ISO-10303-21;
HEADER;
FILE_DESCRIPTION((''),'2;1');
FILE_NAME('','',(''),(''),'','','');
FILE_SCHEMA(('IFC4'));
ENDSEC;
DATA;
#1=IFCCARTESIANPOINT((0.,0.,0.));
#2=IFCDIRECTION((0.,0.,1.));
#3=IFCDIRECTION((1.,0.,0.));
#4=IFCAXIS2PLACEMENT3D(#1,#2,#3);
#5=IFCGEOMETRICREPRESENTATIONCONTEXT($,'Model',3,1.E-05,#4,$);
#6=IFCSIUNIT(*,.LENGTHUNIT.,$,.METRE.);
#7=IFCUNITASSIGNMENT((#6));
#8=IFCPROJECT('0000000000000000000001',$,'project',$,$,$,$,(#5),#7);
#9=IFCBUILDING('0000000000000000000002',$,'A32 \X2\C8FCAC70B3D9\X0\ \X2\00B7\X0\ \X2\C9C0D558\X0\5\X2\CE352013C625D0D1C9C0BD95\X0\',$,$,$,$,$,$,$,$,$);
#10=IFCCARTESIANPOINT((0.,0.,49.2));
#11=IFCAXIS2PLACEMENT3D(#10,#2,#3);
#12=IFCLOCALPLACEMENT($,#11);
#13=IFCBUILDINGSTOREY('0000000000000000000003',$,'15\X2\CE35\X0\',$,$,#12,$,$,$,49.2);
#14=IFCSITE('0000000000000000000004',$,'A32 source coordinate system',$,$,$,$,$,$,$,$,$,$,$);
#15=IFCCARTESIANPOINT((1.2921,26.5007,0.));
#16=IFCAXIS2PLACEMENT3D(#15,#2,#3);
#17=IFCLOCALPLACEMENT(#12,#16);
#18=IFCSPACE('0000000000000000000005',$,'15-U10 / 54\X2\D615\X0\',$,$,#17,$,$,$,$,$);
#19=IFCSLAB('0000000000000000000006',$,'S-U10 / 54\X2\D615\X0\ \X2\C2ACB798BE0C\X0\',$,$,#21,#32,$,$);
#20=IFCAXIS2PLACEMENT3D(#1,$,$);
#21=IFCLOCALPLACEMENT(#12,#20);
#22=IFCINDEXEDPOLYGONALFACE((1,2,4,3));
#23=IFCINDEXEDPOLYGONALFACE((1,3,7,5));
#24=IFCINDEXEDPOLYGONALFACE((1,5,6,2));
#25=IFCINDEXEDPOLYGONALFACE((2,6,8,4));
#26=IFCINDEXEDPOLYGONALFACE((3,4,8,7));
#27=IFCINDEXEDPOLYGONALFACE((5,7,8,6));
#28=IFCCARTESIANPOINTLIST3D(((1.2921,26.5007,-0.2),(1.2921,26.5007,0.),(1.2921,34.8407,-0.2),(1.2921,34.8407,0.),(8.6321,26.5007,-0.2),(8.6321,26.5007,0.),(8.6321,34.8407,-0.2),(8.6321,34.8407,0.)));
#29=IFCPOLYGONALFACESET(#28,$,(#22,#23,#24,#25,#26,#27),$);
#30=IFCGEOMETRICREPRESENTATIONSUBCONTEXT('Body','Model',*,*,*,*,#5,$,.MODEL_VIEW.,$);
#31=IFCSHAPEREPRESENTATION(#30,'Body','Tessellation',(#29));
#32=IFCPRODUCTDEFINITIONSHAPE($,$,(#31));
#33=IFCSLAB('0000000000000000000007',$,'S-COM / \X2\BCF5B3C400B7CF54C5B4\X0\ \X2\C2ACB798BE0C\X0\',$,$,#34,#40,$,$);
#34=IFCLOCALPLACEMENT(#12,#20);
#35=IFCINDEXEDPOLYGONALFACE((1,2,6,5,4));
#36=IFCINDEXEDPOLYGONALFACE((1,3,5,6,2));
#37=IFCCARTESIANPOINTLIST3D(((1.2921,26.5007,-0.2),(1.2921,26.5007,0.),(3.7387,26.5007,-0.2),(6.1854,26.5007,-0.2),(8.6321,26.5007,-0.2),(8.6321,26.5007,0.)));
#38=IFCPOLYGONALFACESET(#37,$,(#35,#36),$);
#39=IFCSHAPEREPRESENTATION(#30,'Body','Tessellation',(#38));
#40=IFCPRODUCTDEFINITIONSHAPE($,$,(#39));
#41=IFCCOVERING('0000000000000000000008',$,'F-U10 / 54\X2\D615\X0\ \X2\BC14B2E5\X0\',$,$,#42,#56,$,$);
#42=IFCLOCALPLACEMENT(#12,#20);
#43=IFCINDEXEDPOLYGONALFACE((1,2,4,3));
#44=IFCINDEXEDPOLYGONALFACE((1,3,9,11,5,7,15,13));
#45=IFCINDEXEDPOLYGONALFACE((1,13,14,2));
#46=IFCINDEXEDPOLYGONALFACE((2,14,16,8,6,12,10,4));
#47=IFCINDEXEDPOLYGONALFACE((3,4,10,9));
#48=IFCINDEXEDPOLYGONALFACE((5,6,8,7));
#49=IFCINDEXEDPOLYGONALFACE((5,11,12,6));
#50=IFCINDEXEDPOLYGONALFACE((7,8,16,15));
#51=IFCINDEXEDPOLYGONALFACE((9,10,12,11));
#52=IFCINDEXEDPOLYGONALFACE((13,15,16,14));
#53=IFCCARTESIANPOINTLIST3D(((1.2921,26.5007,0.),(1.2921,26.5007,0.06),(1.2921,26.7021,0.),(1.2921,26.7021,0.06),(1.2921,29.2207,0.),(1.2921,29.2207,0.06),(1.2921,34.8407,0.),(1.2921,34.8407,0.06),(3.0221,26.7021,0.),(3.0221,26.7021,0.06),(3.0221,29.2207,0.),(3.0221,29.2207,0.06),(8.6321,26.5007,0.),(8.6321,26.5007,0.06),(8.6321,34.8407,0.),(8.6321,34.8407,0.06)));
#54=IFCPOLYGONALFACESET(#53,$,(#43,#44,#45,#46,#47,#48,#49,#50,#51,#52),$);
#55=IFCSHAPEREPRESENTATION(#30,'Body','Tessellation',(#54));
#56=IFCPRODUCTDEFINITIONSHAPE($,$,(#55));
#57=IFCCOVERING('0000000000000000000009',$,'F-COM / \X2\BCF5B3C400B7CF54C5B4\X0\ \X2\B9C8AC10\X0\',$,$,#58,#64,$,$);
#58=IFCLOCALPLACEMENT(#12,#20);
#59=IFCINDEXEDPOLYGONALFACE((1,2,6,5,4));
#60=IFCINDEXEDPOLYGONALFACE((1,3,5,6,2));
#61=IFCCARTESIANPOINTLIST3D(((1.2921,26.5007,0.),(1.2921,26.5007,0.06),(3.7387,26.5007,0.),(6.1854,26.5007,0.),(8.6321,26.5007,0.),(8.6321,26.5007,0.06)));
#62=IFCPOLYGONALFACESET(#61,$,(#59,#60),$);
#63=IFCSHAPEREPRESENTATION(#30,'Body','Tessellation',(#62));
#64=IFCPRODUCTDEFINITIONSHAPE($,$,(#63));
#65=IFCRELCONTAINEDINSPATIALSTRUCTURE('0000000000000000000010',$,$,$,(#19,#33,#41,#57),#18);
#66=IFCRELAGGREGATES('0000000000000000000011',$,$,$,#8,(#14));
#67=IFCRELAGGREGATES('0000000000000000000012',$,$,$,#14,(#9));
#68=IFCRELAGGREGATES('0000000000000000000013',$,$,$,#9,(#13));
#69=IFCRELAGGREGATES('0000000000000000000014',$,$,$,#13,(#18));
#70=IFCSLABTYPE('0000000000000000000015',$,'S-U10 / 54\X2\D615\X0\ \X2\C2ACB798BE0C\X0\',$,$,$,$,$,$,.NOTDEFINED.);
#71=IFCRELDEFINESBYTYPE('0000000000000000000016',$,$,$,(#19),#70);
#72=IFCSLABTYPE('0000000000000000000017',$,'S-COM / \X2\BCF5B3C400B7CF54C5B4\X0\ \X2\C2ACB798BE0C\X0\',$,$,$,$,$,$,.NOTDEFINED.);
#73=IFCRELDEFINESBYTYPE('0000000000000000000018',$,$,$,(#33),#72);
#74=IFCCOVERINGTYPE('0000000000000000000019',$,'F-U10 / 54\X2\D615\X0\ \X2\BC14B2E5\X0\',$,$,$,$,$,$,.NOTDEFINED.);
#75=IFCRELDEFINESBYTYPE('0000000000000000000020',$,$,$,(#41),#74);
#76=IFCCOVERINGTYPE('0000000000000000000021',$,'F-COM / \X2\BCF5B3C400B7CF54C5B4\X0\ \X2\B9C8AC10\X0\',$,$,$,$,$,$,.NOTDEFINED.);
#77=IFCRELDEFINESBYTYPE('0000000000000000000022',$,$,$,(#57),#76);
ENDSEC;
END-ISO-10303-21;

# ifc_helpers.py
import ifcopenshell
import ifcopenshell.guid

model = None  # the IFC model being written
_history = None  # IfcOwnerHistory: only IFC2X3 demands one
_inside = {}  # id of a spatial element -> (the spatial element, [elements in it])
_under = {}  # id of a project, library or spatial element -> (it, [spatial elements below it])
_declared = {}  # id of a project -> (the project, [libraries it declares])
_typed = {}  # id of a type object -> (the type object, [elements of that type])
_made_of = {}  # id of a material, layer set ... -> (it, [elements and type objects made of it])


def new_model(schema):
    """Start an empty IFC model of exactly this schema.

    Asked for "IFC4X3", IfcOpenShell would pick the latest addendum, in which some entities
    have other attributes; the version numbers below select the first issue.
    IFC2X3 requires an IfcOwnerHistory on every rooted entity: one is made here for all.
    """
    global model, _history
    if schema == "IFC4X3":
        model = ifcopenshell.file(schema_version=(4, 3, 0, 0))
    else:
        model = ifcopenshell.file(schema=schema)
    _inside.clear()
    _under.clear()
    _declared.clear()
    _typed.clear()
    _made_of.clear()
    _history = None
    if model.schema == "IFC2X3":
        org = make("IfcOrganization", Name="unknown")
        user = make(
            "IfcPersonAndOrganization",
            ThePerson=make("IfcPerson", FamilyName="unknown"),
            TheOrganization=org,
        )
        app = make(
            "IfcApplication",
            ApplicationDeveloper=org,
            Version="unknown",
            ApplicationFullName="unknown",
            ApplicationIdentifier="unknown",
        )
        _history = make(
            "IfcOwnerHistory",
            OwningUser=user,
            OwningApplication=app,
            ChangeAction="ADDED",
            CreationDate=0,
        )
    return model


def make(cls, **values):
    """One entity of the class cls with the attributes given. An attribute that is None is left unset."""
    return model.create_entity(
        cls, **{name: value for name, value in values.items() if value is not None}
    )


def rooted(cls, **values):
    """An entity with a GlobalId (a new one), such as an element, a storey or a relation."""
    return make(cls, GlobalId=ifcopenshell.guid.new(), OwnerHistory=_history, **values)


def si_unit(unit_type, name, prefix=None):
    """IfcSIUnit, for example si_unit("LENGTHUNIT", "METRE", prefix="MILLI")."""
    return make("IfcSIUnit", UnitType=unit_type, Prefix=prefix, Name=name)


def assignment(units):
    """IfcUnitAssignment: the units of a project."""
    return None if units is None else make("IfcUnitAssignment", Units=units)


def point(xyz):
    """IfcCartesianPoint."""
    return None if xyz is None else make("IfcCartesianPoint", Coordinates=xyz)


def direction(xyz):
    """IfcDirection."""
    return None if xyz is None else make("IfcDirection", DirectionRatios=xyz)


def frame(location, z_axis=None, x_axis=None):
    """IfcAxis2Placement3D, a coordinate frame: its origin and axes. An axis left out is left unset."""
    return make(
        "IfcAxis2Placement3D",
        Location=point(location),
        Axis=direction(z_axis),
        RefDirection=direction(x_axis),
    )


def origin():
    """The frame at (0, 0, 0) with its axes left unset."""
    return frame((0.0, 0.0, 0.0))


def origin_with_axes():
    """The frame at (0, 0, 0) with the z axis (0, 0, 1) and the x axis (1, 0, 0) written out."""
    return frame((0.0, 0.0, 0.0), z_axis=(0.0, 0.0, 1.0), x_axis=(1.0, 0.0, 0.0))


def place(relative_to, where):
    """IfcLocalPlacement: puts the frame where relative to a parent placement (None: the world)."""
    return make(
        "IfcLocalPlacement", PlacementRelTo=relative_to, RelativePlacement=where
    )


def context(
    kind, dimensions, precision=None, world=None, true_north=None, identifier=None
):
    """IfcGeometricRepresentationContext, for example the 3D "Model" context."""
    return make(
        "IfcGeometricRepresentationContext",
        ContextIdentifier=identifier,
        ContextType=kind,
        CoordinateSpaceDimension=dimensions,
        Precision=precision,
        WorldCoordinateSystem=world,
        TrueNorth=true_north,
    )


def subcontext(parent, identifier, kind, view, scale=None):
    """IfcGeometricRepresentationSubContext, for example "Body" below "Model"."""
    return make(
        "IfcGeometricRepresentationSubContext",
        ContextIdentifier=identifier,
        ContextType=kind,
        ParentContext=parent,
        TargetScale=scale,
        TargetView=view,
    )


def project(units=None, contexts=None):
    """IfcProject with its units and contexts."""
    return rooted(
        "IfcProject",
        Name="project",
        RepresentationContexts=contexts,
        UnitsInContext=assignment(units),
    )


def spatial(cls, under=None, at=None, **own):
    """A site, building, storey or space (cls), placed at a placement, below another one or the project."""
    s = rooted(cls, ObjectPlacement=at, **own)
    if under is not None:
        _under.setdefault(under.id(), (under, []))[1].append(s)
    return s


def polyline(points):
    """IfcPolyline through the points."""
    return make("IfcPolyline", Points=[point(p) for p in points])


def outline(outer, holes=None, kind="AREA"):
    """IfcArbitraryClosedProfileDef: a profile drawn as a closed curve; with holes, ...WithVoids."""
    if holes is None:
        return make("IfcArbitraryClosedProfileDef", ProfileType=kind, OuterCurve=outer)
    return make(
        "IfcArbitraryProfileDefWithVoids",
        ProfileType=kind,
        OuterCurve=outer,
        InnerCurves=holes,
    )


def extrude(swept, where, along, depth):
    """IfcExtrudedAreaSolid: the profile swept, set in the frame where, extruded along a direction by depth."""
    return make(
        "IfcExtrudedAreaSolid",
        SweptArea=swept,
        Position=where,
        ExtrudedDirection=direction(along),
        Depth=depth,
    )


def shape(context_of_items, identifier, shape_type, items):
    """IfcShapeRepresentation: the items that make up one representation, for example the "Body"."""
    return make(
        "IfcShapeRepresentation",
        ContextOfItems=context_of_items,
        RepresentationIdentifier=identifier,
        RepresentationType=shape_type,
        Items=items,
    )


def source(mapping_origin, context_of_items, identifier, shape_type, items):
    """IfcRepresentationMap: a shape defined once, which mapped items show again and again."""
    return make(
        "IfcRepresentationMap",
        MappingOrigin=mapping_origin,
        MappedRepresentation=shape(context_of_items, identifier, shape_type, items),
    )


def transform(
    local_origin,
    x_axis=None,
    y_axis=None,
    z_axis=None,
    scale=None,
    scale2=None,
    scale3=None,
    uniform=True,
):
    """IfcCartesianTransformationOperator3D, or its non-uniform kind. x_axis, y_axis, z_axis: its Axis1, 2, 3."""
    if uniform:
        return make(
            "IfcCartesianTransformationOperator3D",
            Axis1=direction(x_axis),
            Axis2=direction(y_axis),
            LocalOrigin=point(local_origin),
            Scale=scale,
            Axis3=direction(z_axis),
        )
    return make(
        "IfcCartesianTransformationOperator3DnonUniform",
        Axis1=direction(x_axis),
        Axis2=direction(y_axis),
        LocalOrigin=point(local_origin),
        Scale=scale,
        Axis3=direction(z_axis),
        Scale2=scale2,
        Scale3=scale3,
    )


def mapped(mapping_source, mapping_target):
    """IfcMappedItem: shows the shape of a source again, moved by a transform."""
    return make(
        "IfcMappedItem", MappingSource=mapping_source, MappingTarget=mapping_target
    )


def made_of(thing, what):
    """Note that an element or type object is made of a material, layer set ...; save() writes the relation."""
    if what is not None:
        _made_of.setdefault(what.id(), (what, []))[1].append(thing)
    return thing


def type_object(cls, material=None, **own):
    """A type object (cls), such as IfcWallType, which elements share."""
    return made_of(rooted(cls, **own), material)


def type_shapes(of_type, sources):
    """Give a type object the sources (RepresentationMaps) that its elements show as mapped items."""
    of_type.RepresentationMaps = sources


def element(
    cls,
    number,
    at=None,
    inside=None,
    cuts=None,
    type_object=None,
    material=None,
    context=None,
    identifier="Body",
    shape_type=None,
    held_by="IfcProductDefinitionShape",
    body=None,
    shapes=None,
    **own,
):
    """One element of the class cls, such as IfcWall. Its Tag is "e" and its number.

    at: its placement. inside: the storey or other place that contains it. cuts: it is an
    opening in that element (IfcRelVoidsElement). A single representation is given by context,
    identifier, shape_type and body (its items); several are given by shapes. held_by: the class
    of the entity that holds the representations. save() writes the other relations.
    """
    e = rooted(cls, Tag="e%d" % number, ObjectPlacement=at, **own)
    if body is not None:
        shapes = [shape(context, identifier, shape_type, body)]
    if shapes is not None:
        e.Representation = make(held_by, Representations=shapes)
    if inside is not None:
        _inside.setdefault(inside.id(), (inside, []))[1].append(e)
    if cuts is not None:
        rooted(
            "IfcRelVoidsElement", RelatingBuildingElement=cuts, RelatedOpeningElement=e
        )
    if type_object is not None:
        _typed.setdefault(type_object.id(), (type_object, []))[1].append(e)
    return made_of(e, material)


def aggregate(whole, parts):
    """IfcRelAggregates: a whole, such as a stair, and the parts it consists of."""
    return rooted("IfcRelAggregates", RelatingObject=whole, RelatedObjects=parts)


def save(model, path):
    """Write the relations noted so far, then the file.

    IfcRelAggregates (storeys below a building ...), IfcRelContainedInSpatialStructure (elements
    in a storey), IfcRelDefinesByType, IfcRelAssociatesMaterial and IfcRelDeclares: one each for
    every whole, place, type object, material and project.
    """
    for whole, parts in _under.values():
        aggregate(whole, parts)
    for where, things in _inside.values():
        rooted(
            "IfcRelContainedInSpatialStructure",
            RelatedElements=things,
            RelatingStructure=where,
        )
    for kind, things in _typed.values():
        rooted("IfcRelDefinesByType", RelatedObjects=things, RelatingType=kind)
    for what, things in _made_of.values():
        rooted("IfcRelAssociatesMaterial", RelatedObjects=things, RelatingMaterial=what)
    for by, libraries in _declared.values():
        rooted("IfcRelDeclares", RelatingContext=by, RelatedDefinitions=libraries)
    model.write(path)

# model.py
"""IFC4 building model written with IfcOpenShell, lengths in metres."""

from ifc_helpers import new_model, si_unit, frame, origin, origin_with_axes, place, context, subcontext, project, spatial, polyline, outline, extrude, source, transform, mapped, type_object, type_shapes, element, save


model = new_model("IFC4")

# Units and contexts
model_context = context("Model", 3, precision=1e-05, world=origin_with_axes())
body_context = subcontext(model_context, "Body", "Model", "MODEL_VIEW")
ifc_project = project(units=[si_unit("LENGTHUNIT", "METRE")], contexts=[model_context])

# Site, building, storey, space
storey_placement = place(None, frame((0.0, 0.0, 49.2), z_axis=(0.0, 0.0, 1.0), x_axis=(1.0, 0.0, 0.0)))
space_placement = place(storey_placement, frame((1.2921, 26.5007, 0.0), z_axis=(0.0, 0.0, 1.0), x_axis=(1.0, 0.0, 0.0)))
site = spatial("IfcSite", under=ifc_project, Name="A32 source coordinate system")
building = spatial("IfcBuilding", under=site, Name="A32 주거동 · 지하5층–옥탑지붕")
storey = spatial("IfcBuildingStorey", under=building, at=storey_placement, Name="15층", Elevation=49.2)
space = spatial("IfcSpace", under=storey, at=space_placement, Name="15-U10 / 54형")

# Slabs
slab_type_1 = type_object("IfcSlabType", Name="S-U10 / 54형 슬래브", PredefinedType="NOTDEFINED")
shared_shape_1 = source(origin(), body_context, "Body", "SweptSolid", [
    extrude(outline(polyline([(0.0, 0.0), (0.0, 8.34), (7.34, 8.34), (7.34, 0.0), (0.0, 0.0)])), frame((0.0, 0.0, -0.2)), (0.0, 0.0, 1.0), 0.2),
])
type_shapes(slab_type_1, [shared_shape_1])
slab_1_placement = place(space_placement, origin_with_axes())
element("IfcSlab", 1, at=slab_1_placement, inside=space, type_object=slab_type_1, Name="S-U10 / 54형 슬래브", context=body_context, shape_type="MappedRepresentation", body=[
    mapped(shared_shape_1, transform((0.0, 0.0, 0.0), scale=1.0)),
])
slab_type_2 = type_object("IfcSlabType", Name="S-COM / 복도·코어 슬래브", PredefinedType="NOTDEFINED")
shared_shape_2 = source(origin(), body_context, "Body", "SweptSolid", [
    extrude(outline(polyline([(7.34, 0.0), (7.34, 0.0), (0.0, 0.0), (0.0, 0.0), (7.34, 0.0)])), frame((0.0, 0.0, -0.2)), (0.0, 0.0, 1.0), 0.2),
])
type_shapes(slab_type_2, [shared_shape_2])
slab_2_placement = place(space_placement, origin_with_axes())
element("IfcSlab", 2, at=slab_2_placement, inside=space, type_object=slab_type_2, Name="S-COM / 복도·코어 슬래브", context=body_context, shape_type="MappedRepresentation", body=[
    mapped(shared_shape_2, transform((0.0, 0.0, 0.0), scale=1.0)),
])

# Coverings
covering_type_1 = type_object("IfcCoveringType", Name="F-U10 / 54형 바닥", PredefinedType="NOTDEFINED")
shared_shape_3 = source(origin(), body_context, "Body", "SweptSolid", [
    extrude(outline(polyline([(7.34, 0.0), (0.0, 0.0), (0.0, 0.2014), (1.73, 0.2014), (1.73, 2.72), (0.0, 2.72), (0.0, 8.34), (7.34, 8.34), (7.34, 0.0)])), origin(), (0.0, 0.0, 1.0), 0.06),
])
type_shapes(covering_type_1, [shared_shape_3])
covering_1_placement = place(space_placement, origin_with_axes())
element("IfcCovering", 3, at=covering_1_placement, inside=space, type_object=covering_type_1, Name="F-U10 / 54형 바닥", context=body_context, shape_type="MappedRepresentation", body=[
    mapped(shared_shape_3, transform((0.0, 0.0, 0.0), scale=1.0)),
])
covering_type_2 = type_object("IfcCoveringType", Name="F-COM / 복도·코어 마감", PredefinedType="NOTDEFINED")
shared_shape_4 = source(origin(), body_context, "Body", "SweptSolid", [
    extrude(outline(polyline([(7.34, 0.0), (7.34, 0.0), (0.0, 0.0), (0.0, 0.0), (7.34, 0.0)])), origin(), (0.0, 0.0, 1.0), 0.06),
])
type_shapes(covering_type_2, [shared_shape_4])
covering_2_placement = place(space_placement, origin_with_axes())
element("IfcCovering", 4, at=covering_2_placement, inside=space, type_object=covering_type_2, Name="F-COM / 복도·코어 마감", context=body_context, shape_type="MappedRepresentation", body=[
    mapped(shared_shape_4, transform((0.0, 0.0, 0.0), scale=1.0)),
])

save(model, "model.ifc")
